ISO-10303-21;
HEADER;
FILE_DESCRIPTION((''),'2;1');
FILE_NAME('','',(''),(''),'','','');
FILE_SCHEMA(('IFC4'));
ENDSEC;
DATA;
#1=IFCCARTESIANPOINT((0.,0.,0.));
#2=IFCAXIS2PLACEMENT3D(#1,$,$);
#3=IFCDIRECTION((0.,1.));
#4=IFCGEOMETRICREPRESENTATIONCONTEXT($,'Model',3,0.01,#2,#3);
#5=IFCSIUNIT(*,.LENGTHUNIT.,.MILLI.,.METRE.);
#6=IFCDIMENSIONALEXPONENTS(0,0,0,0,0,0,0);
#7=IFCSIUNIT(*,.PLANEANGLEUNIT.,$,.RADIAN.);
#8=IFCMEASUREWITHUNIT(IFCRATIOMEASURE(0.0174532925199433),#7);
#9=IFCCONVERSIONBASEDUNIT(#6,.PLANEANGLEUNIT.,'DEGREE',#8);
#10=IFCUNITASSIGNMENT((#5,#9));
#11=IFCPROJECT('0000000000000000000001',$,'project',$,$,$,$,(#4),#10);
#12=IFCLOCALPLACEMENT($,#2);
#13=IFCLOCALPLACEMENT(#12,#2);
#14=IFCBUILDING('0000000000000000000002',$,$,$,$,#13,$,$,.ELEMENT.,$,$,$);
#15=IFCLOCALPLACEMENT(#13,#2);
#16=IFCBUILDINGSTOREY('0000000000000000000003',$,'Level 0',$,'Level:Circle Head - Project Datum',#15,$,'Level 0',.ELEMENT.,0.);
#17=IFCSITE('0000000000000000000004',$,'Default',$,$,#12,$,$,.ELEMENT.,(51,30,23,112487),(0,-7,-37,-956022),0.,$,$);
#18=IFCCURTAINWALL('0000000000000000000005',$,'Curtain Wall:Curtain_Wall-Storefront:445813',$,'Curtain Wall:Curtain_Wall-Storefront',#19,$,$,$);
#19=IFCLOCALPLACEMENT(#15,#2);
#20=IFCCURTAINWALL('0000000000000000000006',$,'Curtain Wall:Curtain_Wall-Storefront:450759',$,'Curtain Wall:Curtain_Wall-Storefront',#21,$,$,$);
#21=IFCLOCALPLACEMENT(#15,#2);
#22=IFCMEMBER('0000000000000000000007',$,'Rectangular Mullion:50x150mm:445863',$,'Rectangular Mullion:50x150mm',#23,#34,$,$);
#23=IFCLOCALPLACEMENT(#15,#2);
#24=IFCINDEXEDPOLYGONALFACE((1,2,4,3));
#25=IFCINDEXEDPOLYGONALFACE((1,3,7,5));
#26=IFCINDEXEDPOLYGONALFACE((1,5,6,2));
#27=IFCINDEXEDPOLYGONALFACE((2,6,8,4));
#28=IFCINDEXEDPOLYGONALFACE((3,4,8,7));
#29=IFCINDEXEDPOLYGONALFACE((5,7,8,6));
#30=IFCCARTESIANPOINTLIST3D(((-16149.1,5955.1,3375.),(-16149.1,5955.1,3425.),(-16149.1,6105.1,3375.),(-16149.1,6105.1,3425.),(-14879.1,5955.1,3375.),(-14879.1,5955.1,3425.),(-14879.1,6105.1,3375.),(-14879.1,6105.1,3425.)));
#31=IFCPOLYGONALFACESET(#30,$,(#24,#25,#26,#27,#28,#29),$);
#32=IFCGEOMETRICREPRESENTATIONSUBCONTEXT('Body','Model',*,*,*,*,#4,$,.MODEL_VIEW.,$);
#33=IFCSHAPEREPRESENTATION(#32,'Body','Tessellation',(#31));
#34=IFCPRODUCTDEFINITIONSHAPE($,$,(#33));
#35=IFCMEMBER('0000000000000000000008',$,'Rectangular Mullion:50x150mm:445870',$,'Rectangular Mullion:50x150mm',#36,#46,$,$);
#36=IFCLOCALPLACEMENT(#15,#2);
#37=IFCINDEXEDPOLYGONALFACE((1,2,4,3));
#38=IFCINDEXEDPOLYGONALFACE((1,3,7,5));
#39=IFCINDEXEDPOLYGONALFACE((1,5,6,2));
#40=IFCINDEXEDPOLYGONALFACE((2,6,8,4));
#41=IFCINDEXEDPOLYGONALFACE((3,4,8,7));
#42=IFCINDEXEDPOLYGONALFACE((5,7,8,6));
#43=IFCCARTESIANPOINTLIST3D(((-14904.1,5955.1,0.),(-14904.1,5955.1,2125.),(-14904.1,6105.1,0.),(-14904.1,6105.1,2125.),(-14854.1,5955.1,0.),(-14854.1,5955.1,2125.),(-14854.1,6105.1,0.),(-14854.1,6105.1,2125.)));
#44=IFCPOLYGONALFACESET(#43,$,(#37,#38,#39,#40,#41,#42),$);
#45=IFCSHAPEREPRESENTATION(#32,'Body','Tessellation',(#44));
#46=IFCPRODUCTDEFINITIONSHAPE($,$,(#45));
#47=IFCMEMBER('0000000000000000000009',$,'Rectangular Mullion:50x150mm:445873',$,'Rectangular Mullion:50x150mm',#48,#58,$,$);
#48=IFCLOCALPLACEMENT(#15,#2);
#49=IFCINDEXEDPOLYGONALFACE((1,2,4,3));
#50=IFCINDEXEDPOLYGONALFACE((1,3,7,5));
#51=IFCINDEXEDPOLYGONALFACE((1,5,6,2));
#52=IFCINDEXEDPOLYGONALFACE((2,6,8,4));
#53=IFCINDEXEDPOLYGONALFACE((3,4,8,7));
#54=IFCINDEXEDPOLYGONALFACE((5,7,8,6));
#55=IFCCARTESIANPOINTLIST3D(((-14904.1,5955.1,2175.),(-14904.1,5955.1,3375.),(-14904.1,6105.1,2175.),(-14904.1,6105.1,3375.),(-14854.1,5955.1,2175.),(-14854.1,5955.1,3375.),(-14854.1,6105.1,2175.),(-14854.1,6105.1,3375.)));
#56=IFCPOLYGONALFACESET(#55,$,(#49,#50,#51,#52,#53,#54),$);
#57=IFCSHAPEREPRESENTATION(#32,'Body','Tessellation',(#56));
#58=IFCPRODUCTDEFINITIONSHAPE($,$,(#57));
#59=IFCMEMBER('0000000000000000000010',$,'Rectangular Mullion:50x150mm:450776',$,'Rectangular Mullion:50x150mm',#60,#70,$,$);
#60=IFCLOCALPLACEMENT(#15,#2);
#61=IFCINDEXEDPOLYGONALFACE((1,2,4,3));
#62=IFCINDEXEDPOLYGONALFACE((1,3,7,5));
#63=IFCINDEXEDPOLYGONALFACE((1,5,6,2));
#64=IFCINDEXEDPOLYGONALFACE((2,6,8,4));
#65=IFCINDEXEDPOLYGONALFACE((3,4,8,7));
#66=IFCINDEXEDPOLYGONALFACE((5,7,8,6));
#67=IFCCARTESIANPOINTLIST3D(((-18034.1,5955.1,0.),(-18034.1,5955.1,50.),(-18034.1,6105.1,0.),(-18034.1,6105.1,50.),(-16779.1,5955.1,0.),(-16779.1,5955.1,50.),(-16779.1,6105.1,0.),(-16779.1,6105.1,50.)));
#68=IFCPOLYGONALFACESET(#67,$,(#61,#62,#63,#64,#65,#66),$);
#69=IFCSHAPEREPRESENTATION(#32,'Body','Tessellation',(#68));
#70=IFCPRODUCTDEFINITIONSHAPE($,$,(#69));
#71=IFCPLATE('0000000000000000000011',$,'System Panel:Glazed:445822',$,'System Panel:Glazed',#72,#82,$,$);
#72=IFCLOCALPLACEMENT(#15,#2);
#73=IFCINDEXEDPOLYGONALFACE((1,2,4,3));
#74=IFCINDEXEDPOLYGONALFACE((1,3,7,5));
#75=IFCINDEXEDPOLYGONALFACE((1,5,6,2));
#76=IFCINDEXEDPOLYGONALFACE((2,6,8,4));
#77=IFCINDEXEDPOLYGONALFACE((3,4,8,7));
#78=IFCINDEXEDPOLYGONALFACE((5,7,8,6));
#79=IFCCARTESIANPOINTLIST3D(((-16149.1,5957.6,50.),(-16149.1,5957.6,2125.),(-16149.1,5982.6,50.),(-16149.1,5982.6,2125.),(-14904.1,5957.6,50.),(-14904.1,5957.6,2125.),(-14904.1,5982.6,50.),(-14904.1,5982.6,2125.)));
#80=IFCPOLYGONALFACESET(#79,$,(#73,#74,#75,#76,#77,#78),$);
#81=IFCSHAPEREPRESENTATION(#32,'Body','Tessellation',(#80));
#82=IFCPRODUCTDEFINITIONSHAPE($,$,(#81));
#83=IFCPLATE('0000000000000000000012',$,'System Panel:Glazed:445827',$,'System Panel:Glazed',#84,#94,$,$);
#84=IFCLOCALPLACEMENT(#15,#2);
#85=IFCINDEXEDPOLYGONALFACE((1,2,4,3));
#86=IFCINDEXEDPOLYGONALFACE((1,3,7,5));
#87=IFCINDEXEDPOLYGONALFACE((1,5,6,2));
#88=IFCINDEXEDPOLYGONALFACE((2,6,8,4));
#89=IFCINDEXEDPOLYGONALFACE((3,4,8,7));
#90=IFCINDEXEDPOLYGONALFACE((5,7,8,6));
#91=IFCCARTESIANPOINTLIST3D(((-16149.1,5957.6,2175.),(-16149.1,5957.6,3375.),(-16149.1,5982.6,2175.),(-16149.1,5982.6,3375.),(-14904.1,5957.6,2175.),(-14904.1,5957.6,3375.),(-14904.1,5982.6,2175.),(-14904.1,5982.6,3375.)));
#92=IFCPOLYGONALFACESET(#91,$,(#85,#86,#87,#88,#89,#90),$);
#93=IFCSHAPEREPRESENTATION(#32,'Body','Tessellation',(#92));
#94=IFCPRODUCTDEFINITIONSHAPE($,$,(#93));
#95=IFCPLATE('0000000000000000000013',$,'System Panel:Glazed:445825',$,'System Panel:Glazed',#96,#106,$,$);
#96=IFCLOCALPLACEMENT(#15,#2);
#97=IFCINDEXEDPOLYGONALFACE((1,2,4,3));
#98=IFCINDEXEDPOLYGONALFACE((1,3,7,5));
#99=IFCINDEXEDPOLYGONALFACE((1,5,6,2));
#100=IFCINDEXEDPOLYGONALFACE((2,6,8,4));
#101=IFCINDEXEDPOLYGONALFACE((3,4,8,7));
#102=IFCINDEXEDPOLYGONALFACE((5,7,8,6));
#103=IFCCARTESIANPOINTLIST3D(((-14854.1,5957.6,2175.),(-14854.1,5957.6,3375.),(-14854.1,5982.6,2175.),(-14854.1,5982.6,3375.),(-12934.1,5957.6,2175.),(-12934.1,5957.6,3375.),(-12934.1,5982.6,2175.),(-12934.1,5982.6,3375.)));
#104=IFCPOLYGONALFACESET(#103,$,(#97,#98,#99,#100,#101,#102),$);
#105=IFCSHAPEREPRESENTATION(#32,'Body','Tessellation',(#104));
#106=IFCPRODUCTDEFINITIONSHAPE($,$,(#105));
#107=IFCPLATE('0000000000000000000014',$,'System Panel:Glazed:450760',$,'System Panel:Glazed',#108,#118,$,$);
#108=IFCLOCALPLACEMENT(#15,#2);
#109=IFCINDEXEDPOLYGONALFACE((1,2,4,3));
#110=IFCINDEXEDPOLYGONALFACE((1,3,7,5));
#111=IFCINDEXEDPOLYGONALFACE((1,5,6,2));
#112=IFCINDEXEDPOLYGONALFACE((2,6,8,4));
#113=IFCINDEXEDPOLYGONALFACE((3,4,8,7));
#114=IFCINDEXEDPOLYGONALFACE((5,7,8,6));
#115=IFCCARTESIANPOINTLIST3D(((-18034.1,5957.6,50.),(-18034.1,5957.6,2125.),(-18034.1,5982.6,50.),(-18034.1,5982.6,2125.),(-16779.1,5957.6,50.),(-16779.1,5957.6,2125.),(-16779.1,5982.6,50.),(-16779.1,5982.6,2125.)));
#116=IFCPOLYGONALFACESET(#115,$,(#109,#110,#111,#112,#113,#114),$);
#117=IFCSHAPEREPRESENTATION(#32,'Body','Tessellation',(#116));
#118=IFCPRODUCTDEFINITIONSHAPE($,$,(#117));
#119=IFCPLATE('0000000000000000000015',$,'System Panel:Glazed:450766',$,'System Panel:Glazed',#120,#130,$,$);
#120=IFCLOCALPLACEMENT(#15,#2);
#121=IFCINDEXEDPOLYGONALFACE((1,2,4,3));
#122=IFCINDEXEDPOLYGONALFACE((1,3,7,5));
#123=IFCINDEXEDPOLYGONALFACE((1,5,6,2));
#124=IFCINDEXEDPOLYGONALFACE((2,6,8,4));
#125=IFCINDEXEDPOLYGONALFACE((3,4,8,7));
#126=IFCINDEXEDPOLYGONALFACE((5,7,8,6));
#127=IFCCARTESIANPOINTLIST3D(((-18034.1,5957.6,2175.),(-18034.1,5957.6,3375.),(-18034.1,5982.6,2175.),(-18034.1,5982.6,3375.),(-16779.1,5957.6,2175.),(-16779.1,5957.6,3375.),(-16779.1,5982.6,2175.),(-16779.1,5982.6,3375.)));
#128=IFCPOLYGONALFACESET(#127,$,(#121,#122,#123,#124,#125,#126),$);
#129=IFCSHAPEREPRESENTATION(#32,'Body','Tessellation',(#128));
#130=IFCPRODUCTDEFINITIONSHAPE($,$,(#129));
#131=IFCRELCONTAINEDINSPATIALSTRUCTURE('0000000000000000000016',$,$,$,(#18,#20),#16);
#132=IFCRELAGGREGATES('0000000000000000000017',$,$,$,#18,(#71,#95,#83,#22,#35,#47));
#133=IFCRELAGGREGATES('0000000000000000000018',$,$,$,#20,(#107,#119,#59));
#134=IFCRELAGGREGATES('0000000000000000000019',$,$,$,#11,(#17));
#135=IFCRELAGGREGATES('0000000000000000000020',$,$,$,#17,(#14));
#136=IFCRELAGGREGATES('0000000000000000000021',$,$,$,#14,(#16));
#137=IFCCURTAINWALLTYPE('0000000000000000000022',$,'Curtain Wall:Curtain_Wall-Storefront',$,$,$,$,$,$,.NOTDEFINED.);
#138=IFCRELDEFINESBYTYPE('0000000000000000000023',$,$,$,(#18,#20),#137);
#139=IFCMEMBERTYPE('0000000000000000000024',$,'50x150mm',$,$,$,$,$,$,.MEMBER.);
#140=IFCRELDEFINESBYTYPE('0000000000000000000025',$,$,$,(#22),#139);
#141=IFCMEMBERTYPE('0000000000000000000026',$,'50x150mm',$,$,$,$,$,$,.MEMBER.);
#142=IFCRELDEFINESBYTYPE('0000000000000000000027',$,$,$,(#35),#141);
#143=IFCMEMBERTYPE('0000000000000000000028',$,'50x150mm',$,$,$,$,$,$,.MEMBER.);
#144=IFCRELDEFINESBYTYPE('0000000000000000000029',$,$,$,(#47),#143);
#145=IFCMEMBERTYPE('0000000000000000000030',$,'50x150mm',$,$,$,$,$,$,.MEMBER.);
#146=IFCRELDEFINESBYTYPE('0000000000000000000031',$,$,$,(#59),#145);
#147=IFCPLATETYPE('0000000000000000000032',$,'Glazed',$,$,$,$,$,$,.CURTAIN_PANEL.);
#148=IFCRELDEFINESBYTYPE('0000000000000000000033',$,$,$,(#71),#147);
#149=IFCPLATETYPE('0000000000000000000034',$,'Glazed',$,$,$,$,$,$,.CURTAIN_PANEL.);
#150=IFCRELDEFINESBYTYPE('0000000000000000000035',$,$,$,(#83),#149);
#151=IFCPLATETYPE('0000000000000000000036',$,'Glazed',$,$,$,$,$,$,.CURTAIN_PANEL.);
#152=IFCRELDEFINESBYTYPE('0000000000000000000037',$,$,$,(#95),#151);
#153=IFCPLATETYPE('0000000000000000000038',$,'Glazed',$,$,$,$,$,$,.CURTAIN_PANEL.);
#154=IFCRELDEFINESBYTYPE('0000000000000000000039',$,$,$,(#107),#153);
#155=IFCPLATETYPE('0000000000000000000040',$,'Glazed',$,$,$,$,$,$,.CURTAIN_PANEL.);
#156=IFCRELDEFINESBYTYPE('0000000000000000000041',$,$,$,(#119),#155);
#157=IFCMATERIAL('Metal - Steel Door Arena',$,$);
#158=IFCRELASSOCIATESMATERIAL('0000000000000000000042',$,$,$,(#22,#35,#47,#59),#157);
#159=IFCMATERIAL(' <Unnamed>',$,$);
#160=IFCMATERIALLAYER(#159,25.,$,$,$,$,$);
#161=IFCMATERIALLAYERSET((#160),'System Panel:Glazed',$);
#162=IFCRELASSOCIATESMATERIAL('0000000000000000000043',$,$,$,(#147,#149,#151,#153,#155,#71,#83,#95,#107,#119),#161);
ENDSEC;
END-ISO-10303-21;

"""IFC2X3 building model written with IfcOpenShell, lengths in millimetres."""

from ifc_helpers import new_model, entity, si_unit, converted_unit, direction, frame, origin, origin_2d_with_axis, place, context, subcontext, project, spatial, rectangle, extrude, source, transform, mapped, material, layer, layer_set, layer_usage, type_object, type_shapes, element, aggregate, save


model = new_model("IFC2X3")

# Units and contexts
model_context = context("Model", 3, precision=0.01, world=origin(), true_north=direction((0.0, 1.0)))
body_context = subcontext(model_context, "Body", "Model", "MODEL_VIEW")
ifc_project = project(units=[si_unit("LENGTHUNIT", "METRE", prefix="MILLI"), converted_unit("PLANEANGLEUNIT", "DEGREE", entity("IfcRatioMeasure", 0.0174532925199433), si_unit("PLANEANGLEUNIT", "RADIAN"), dimensions=[0, 0, 0, 0, 0, 0, 0])], contexts=[model_context])

# Site, building, storey
site_placement = place(None, origin())
site = spatial("IfcSite", under=ifc_project, at=site_placement, Name="Default", CompositionType="ELEMENT", RefLatitude=(51, 30, 23, 112487), RefLongitude=(0, -7, -37, -956022), RefElevation=0.0)
building_placement = place(site_placement, origin())
building = spatial("IfcBuilding", under=site, at=building_placement, CompositionType="ELEMENT")
storey_placement = place(building_placement, origin())
storey = spatial("IfcBuildingStorey", under=building, at=storey_placement, Name="Level 0", ObjectType="Level:Circle Head - Project Datum", LongName="Level 0", CompositionType="ELEMENT", Elevation=0.0)

# Curtain walls
curtain_wall_type = type_object("IfcCurtainWallType", Name="Curtain Wall:Curtain_Wall-Storefront", PredefinedType="NOTDEFINED")
curtain_wall_1_placement = place(storey_placement, origin())
curtain_wall_1 = element("IfcCurtainWall", 1, at=curtain_wall_1_placement, inside=storey, type_object=curtain_wall_type, Name="Curtain Wall:Curtain_Wall-Storefront:445813", ObjectType="Curtain Wall:Curtain_Wall-Storefront")
ifc_material_1 = material(Name="Metal - Steel Door Arena")
curtain_wall_2_placement = place(storey_placement, origin())
curtain_wall_2 = element("IfcCurtainWall", 2, at=curtain_wall_2_placement, inside=storey, type_object=curtain_wall_type, Name="Curtain Wall:Curtain_Wall-Storefront:450759", ObjectType="Curtain Wall:Curtain_Wall-Storefront")

# Members
member_type_1 = type_object("IfcMemberType", Name="50x150mm", PredefinedType="MEMBER")
shared_shape_1 = source(origin(), body_context, "Body", "SweptSolid", [
    extrude(rectangle(XDim=150.0, YDim=50.0, at=origin_2d_with_axis()), frame((0.0, 0.0, -1270.0), z_axis=(0.0, 0.0, 1.0), x_axis=(0.0, -1.0, 0.0)), (0.0, 0.0, 1.0), 1270.0),
])
type_shapes(member_type_1, [shared_shape_1])
member_1_placement = place(storey_placement, frame((-16149.1, 6030.1, 3400.0), z_axis=(-1.0, 0.0, 0.0), x_axis=(0.0, 0.0, 1.0)))
member_1 = element("IfcMember", 3, at=member_1_placement, type_object=member_type_1, material=ifc_material_1, Name="Rectangular Mullion:50x150mm:445863", ObjectType="Rectangular Mullion:50x150mm", context=body_context, shape_type="MappedRepresentation", body=[
    mapped(shared_shape_1, transform((0.0, 0.0, 0.0), scale=1.0)),
])
member_type_2 = type_object("IfcMemberType", Name="50x150mm", PredefinedType="MEMBER")
shared_shape_2 = source(origin(), body_context, "Body", "SweptSolid", [
    extrude(rectangle(XDim=150.0, YDim=50.0, at=origin_2d_with_axis()), frame((0.0, 0.0, -2125.0), z_axis=(0.0, 0.0, 1.0), x_axis=(0.0, -1.0, 0.0)), (0.0, 0.0, 1.0), 2125.0),
])
type_shapes(member_type_2, [shared_shape_2])
member_2_placement = place(storey_placement, frame((-14879.1, 6030.1, 0.0), z_axis=(0.0, 0.0, -1.0), x_axis=(-1.0, 0.0, 0.0)))
member_2 = element("IfcMember", 4, at=member_2_placement, type_object=member_type_2, material=ifc_material_1, Name="Rectangular Mullion:50x150mm:445870", ObjectType="Rectangular Mullion:50x150mm", context=body_context, shape_type="MappedRepresentation", body=[
    mapped(shared_shape_2, transform((0.0, 0.0, 0.0), scale=1.0)),
])
member_type_3 = type_object("IfcMemberType", Name="50x150mm", PredefinedType="MEMBER")
shared_shape_3 = source(origin(), body_context, "Body", "SweptSolid", [
    extrude(rectangle(XDim=150.0, YDim=50.0, at=origin_2d_with_axis()), frame((0.0, 0.0, -1200.0), z_axis=(0.0, 0.0, 1.0), x_axis=(0.0, -1.0, 0.0)), (0.0, 0.0, 1.0), 1200.0),
])
type_shapes(member_type_3, [shared_shape_3])
member_3_placement = place(storey_placement, frame((-14879.1, 6030.1, 2175.0), z_axis=(0.0, 0.0, -1.0), x_axis=(-1.0, 0.0, 0.0)))
member_3 = element("IfcMember", 5, at=member_3_placement, type_object=member_type_3, material=ifc_material_1, Name="Rectangular Mullion:50x150mm:445873", ObjectType="Rectangular Mullion:50x150mm", context=body_context, shape_type="MappedRepresentation", body=[
    mapped(shared_shape_3, transform((0.0, 0.0, 0.0), scale=1.0)),
])
member_type_4 = type_object("IfcMemberType", Name="50x150mm", PredefinedType="MEMBER")
shared_shape_4 = source(origin(), body_context, "Body", "SweptSolid", [
    extrude(rectangle(XDim=150.0, YDim=50.0, at=origin_2d_with_axis()), frame((-25.0, 0.0, -1255.0), z_axis=(0.0, 0.0, 1.0), x_axis=(0.0, -1.0, 0.0)), (0.0, 0.0, 1.0), 1255.0),
])
type_shapes(member_type_4, [shared_shape_4])
member_4_placement = place(storey_placement, frame((-16779.1, 6030.1, 0.0), z_axis=(1.0, 0.0, 0.0), x_axis=(0.0, 0.0, -1.0)))
member_4 = element("IfcMember", 6, at=member_4_placement, type_object=member_type_4, material=ifc_material_1, Name="Rectangular Mullion:50x150mm:450776", ObjectType="Rectangular Mullion:50x150mm", context=body_context, shape_type="MappedRepresentation", body=[
    mapped(shared_shape_4, transform((0.0, 0.0, 0.0), scale=1.0)),
])

# Plates
ifc_material_2 = material(Name=" <Unnamed>")
ifc_layer = layer(ifc_material_2, 25.0)
ifc_layer_set = layer_set([ifc_layer], Name="System Panel:Glazed")
ifc_layer_usage_1 = layer_usage(ifc_layer_set, "AXIS3", "POSITIVE", 0.2)
plate_type_1 = type_object("IfcPlateType", Name="Glazed", PredefinedType="CURTAIN_PANEL", material=ifc_layer_set)
shared_shape_5 = source(origin(), body_context, "Body", "SweptSolid", [
    extrude(rectangle(XDim=25.0, YDim=1245.0, at=origin_2d_with_axis()), frame((0.0, 60.0, 0.0), z_axis=(0.0, 0.0, 1.0), x_axis=(0.0, 1.0, 0.0)), (0.0, 0.0, 1.0), 2075.0),
])
type_shapes(plate_type_1, [shared_shape_5])
plate_1_placement = place(curtain_wall_1_placement, frame((-15526.6, 6030.1, 50.0), z_axis=(0.0, 0.0, 1.0), x_axis=(-1.0, 0.0, 0.0)))
plate_1 = element("IfcPlate", 7, at=plate_1_placement, type_object=plate_type_1, material=ifc_layer_usage_1, Name="System Panel:Glazed:445822", ObjectType="System Panel:Glazed", context=body_context, shape_type="MappedRepresentation", body=[
    mapped(shared_shape_5, transform((0.0, 0.0, 0.0), scale=1.0)),
])
ifc_layer_usage_2 = layer_usage(ifc_layer_set, "AXIS3", "POSITIVE", 0.2)
plate_type_2 = type_object("IfcPlateType", Name="Glazed", PredefinedType="CURTAIN_PANEL", material=ifc_layer_set)
shared_shape_6 = source(origin(), body_context, "Body", "SweptSolid", [
    extrude(rectangle(XDim=25.0, YDim=1245.0, at=origin_2d_with_axis()), frame((0.0, 60.0, 0.0), z_axis=(0.0, 0.0, 1.0), x_axis=(0.0, 1.0, 0.0)), (0.0, 0.0, 1.0), 1200.0),
])
type_shapes(plate_type_2, [shared_shape_6])
plate_2_placement = place(curtain_wall_1_placement, frame((-15526.6, 6030.1, 2175.0), z_axis=(0.0, 0.0, 1.0), x_axis=(-1.0, 0.0, 0.0)))
plate_2 = element("IfcPlate", 8, at=plate_2_placement, type_object=plate_type_2, material=ifc_layer_usage_2, Name="System Panel:Glazed:445827", ObjectType="System Panel:Glazed", context=body_context, shape_type="MappedRepresentation", body=[
    mapped(shared_shape_6, transform((0.0, 0.0, 0.0), scale=1.0)),
])
ifc_layer_usage_3 = layer_usage(ifc_layer_set, "AXIS3", "POSITIVE", 0.2)
plate_type_3 = type_object("IfcPlateType", Name="Glazed", PredefinedType="CURTAIN_PANEL", material=ifc_layer_set)
shared_shape_7 = source(origin(), body_context, "Body", "SweptSolid", [
    extrude(rectangle(XDim=25.0, YDim=1920.0, at=origin_2d_with_axis()), frame((0.0, 60.0, 0.0), z_axis=(0.0, 0.0, 1.0), x_axis=(0.0, 1.0, 0.0)), (0.0, 0.0, 1.0), 1200.0),
])
type_shapes(plate_type_3, [shared_shape_7])
plate_3_placement = place(curtain_wall_1_placement, frame((-13894.1, 6030.1, 2175.0), z_axis=(0.0, 0.0, 1.0), x_axis=(-1.0, 0.0, 0.0)))
plate_3 = element("IfcPlate", 9, at=plate_3_placement, type_object=plate_type_3, material=ifc_layer_usage_3, Name="System Panel:Glazed:445825", ObjectType="System Panel:Glazed", context=body_context, shape_type="MappedRepresentation", body=[
    mapped(shared_shape_7, transform((0.0, 0.0, 0.0), scale=1.0)),
])
aggregate(curtain_wall_1, [plate_1, plate_3, plate_2, member_1, member_2, member_3])
ifc_layer_usage_4 = layer_usage(ifc_layer_set, "AXIS3", "POSITIVE", 0.2)
plate_type_4 = type_object("IfcPlateType", Name="Glazed", PredefinedType="CURTAIN_PANEL", material=ifc_layer_set)
shared_shape_8 = source(origin(), body_context, "Body", "SweptSolid", [
    extrude(rectangle(XDim=25.0, YDim=1255.0, at=origin_2d_with_axis()), frame((0.0, 60.0, 0.0), z_axis=(0.0, 0.0, 1.0), x_axis=(0.0, 1.0, 0.0)), (0.0, 0.0, 1.0), 2075.0),
])
type_shapes(plate_type_4, [shared_shape_8])
plate_4_placement = place(curtain_wall_2_placement, frame((-17406.6, 6030.1, 50.0), z_axis=(0.0, 0.0, 1.0), x_axis=(-1.0, 0.0, 0.0)))
plate_4 = element("IfcPlate", 10, at=plate_4_placement, type_object=plate_type_4, material=ifc_layer_usage_4, Name="System Panel:Glazed:450760", ObjectType="System Panel:Glazed", context=body_context, shape_type="MappedRepresentation", body=[
    mapped(shared_shape_8, transform((0.0, 0.0, 0.0), scale=1.0)),
])
ifc_layer_usage_5 = layer_usage(ifc_layer_set, "AXIS3", "POSITIVE", 0.2)
plate_type_5 = type_object("IfcPlateType", Name="Glazed", PredefinedType="CURTAIN_PANEL", material=ifc_layer_set)
shared_shape_9 = source(origin(), body_context, "Body", "SweptSolid", [
    extrude(rectangle(XDim=25.0, YDim=1255.0, at=origin_2d_with_axis()), frame((0.0, 60.0, 0.0), z_axis=(0.0, 0.0, 1.0), x_axis=(0.0, 1.0, 0.0)), (0.0, 0.0, 1.0), 1200.0),
])
type_shapes(plate_type_5, [shared_shape_9])
plate_5_placement = place(curtain_wall_2_placement, frame((-17406.6, 6030.1, 2175.0), z_axis=(0.0, 0.0, 1.0), x_axis=(-1.0, 0.0, 0.0)))
plate_5 = element("IfcPlate", 11, at=plate_5_placement, type_object=plate_type_5, material=ifc_layer_usage_5, Name="System Panel:Glazed:450766", ObjectType="System Panel:Glazed", context=body_context, shape_type="MappedRepresentation", body=[
    mapped(shared_shape_9, transform((0.0, 0.0, 0.0), scale=1.0)),
])
aggregate(curtain_wall_2, [plate_4, plate_5, member_4])

save(model, "model.ifc")
